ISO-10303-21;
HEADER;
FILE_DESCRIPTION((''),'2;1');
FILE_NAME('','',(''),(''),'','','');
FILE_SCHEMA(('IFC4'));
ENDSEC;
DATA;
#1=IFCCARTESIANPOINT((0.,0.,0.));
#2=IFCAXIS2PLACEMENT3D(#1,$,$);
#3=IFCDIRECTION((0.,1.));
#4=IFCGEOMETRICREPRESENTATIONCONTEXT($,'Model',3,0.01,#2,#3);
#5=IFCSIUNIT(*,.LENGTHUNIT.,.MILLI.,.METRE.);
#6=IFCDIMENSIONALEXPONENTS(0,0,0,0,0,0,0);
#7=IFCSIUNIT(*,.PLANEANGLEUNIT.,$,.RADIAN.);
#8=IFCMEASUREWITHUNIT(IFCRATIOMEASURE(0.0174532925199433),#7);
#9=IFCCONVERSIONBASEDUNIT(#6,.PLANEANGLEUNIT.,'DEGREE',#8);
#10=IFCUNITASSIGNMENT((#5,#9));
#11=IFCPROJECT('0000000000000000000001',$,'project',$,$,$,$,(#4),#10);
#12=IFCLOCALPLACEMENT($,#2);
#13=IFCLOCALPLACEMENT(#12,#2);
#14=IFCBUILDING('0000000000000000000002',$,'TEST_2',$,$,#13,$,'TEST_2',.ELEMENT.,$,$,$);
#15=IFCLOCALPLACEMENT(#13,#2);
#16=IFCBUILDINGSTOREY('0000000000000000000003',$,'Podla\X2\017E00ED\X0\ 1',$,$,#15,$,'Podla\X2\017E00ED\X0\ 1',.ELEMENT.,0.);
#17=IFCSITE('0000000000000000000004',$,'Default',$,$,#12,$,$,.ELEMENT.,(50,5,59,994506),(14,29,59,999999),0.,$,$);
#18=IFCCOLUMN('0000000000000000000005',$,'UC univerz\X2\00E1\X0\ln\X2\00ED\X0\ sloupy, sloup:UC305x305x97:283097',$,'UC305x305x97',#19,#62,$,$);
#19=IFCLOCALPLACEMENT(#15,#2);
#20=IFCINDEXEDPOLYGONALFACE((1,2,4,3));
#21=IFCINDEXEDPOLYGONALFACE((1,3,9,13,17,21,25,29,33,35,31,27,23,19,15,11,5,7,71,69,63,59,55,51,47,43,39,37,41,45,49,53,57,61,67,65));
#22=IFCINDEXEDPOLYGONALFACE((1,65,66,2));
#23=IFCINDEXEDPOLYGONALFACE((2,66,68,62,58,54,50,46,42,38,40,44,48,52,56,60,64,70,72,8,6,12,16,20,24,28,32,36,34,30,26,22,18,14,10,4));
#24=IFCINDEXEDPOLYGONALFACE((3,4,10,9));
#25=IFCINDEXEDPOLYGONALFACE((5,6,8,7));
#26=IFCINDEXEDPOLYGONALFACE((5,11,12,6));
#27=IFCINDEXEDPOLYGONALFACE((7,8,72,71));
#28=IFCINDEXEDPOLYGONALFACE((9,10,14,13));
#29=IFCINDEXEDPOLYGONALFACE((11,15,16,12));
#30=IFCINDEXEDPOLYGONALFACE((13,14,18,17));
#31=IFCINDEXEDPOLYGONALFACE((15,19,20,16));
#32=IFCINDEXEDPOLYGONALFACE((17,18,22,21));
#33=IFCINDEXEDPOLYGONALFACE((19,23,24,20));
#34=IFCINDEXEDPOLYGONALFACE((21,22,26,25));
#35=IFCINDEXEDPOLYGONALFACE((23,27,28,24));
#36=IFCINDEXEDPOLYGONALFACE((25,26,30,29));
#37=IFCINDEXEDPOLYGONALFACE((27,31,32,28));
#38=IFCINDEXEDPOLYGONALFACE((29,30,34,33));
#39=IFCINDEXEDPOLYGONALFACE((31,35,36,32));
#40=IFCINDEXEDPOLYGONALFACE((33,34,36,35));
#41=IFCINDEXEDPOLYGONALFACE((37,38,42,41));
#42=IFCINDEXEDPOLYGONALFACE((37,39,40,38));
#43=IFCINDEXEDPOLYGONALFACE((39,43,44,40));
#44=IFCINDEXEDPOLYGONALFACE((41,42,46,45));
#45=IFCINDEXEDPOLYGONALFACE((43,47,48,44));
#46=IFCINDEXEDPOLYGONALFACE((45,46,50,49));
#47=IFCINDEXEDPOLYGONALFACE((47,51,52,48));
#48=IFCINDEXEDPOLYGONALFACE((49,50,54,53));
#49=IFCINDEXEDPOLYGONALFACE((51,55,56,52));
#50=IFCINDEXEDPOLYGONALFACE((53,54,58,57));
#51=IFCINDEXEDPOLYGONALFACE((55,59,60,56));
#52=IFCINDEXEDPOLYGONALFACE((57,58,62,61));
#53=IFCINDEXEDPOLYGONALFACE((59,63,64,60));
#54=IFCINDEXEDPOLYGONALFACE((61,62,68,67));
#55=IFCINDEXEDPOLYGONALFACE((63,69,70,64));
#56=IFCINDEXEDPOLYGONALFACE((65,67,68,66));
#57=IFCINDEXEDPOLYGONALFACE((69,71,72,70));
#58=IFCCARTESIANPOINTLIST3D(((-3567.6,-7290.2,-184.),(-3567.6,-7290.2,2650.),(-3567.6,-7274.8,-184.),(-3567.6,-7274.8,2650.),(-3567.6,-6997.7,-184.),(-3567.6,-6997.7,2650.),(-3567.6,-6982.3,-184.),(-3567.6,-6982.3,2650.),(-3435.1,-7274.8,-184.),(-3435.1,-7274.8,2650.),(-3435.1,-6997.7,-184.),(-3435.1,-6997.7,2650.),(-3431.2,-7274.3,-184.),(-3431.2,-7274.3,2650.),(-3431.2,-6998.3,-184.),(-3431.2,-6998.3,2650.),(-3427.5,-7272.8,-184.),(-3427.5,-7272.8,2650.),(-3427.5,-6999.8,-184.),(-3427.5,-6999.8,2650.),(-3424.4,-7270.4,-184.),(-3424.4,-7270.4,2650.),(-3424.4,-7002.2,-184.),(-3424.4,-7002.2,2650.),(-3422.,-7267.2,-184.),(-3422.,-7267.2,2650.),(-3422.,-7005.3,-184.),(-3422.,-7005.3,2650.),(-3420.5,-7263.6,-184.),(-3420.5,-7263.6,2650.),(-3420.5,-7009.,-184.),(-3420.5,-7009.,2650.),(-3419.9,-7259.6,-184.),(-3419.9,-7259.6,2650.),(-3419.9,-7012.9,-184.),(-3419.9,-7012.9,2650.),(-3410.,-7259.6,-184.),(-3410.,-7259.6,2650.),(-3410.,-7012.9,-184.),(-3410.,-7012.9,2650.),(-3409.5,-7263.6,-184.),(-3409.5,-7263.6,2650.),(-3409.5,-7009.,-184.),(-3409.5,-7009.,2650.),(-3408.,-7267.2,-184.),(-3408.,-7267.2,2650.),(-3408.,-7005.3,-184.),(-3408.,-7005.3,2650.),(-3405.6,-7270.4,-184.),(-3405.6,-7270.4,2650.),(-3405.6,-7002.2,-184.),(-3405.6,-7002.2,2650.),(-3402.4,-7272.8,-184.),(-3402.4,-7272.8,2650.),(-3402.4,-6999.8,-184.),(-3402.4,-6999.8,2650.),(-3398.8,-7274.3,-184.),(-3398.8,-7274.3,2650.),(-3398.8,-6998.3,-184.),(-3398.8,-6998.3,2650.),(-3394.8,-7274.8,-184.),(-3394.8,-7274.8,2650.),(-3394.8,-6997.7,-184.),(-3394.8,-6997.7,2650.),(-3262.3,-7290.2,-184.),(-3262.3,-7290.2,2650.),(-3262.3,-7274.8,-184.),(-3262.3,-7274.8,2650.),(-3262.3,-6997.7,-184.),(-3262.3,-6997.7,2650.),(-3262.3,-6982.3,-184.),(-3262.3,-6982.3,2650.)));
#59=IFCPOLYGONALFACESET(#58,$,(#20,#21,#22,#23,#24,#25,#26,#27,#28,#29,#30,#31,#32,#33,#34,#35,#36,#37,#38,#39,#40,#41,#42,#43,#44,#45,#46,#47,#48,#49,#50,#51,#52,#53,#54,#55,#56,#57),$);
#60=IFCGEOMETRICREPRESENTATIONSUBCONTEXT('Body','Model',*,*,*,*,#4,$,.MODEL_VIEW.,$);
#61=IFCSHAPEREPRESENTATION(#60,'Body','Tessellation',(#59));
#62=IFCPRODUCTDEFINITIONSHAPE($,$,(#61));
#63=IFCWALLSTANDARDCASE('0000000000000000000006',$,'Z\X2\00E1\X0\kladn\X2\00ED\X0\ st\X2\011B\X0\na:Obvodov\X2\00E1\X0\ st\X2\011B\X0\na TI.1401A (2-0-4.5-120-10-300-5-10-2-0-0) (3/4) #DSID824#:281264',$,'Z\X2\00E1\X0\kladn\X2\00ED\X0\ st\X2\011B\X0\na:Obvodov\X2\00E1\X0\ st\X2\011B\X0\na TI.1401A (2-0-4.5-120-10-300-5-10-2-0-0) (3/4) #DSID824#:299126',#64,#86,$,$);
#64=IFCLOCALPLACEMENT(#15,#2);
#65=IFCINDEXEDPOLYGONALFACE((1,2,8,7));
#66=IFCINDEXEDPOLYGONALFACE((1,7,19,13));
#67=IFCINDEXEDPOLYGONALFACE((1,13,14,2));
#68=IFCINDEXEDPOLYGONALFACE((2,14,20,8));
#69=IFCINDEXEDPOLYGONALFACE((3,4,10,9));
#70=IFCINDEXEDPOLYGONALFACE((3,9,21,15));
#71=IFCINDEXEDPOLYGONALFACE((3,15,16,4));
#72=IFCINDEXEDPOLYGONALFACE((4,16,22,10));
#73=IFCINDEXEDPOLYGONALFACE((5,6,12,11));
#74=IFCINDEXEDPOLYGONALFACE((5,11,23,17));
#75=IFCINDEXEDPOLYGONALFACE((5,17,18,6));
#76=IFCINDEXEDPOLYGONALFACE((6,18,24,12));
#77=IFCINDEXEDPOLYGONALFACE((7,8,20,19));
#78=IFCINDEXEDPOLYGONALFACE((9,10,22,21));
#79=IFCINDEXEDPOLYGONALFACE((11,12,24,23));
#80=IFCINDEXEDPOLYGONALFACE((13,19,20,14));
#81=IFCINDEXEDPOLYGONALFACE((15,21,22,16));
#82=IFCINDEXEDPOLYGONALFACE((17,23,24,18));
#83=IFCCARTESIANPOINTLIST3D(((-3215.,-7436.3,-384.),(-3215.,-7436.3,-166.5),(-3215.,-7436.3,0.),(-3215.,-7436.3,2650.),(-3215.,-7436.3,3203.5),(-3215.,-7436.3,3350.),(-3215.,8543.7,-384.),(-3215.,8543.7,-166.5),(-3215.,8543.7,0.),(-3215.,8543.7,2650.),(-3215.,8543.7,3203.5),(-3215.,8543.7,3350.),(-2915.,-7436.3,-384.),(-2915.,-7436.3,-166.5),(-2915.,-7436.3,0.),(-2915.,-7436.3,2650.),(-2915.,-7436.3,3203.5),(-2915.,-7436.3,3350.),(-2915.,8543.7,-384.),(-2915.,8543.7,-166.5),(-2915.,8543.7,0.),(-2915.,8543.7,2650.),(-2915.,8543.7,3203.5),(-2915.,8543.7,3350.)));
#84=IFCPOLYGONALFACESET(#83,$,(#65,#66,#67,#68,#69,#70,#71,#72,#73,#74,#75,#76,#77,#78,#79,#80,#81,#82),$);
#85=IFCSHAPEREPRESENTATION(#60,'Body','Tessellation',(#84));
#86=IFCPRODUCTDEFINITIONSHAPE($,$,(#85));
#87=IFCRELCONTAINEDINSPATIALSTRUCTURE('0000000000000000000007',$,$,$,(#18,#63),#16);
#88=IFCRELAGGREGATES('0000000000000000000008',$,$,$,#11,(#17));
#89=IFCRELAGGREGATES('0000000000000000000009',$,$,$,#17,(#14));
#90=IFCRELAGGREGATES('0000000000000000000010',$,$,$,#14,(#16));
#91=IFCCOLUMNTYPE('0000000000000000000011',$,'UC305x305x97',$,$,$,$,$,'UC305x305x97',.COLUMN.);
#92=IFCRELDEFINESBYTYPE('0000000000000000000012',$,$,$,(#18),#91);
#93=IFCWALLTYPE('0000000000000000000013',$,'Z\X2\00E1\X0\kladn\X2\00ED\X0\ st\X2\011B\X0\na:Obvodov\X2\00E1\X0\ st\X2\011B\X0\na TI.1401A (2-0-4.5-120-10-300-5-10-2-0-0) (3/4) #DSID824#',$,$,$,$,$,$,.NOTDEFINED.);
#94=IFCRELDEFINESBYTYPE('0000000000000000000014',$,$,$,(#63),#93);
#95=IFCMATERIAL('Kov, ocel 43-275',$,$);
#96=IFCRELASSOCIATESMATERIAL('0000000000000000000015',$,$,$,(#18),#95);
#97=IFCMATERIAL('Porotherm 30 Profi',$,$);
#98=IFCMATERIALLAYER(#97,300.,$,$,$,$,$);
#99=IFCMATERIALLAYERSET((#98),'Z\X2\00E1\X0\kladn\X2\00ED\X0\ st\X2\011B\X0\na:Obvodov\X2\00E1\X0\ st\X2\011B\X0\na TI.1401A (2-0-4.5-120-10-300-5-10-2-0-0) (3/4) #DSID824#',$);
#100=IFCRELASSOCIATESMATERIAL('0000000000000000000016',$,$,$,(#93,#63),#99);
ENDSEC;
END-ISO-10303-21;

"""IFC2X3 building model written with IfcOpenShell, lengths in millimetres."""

from ifc_helpers import new_model, entity, si_unit, converted_unit, direction, frame, frame_2d, origin, origin_2d_with_axis, place, context, subcontext, project, spatial, rectangle, i_section, extrude, source, transform, mapped, material, layer, layer_set, layer_usage, type_object, type_shapes, element, save


model = new_model("IFC2X3")

# Units and contexts
model_context = context("Model", 3, precision=0.01, world=origin(), true_north=direction((0.0, 1.0)))
body_context = subcontext(model_context, "Body", "Model", "MODEL_VIEW")
ifc_project = project(units=[si_unit("LENGTHUNIT", "METRE", prefix="MILLI"), converted_unit("PLANEANGLEUNIT", "DEGREE", entity("IfcRatioMeasure", 0.0174532925199433), si_unit("PLANEANGLEUNIT", "RADIAN"), dimensions=[0, 0, 0, 0, 0, 0, 0])], contexts=[model_context])

# Site, building, storey
site_placement = place(None, origin())
site = spatial("IfcSite", under=ifc_project, at=site_placement, Name="Default", CompositionType="ELEMENT", RefLatitude=(50, 5, 59, 994506), RefLongitude=(14, 29, 59, 999999), RefElevation=0.0)
building_placement = place(site_placement, origin())
building = spatial("IfcBuilding", under=site, at=building_placement, Name="TEST_2", LongName="TEST_2", CompositionType="ELEMENT")
storey_placement = place(building_placement, origin())
storey = spatial("IfcBuildingStorey", under=building, at=storey_placement, Name="Podlaží 1", LongName="Podlaží 1", CompositionType="ELEMENT", Elevation=0.0)

# Column
ifc_material_1 = material(Name="Kov, ocel 43-275")
column_type = type_object("IfcColumnType", Name="UC305x305x97", ElementType="UC305x305x97", PredefinedType="COLUMN")
shared_shape = source(origin(), body_context, "Body", "SweptSolid", [
    extrude(i_section(OverallWidth=305.3, OverallDepth=307.9, WebThickness=9.9, FlangeThickness=15.4, FilletRadius=15.2, at=origin_2d_with_axis()), frame((0.0, 0.0, -184.0), z_axis=(0.0, 0.0, 1.0), x_axis=(-1.0, 0.0, 0.0)), (0.0, 0.0, 1.0), 2834.0),
])
type_shapes(column_type, [shared_shape])
column_placement = place(storey_placement, frame((-3415.0, -7136.3, 0.0)))
element("IfcColumn", 1, at=column_placement, inside=storey, type_object=column_type, material=ifc_material_1, Name="UC univerzální sloupy, sloup:UC305x305x97:283097", ObjectType="UC305x305x97", context=body_context, shape_type="MappedRepresentation", body=[
    mapped(shared_shape, transform((0.0, 0.0, 0.0), scale=1.0)),
])

# Wall, openings
ifc_material_2 = material(Name="Porotherm 30 Profi")
ifc_layer_1 = layer(ifc_material_2, 300.0)
ifc_layer_set_1 = layer_set([ifc_layer_1], Name="Základní stěna:Obvodová stěna TI.1401A (2-0-4.5-120-10-300-5-10-2-0-0) (3/4) #DSID824#")
ifc_layer_usage_1 = layer_usage(ifc_layer_set_1, "AXIS2", "POSITIVE", -150.0)
wall_type_1 = type_object("IfcWallType", Name="Základní stěna:Obvodová stěna TI.1401A (2-0-4.5-120-10-300-5-10-2-0-0) (3/4) #DSID824#", PredefinedType="NOTDEFINED", material=ifc_layer_set_1)
wall_1_placement = place(storey_placement, frame((-3065.0, -7436.3, -384.0), z_axis=(0.0, 0.0, 1.0), x_axis=(0.0, 1.0, 0.0)))
wall_1 = element("IfcWallStandardCase", 2, at=wall_1_placement, inside=storey, type_object=wall_type_1, material=ifc_layer_usage_1, Name="Základní stěna:Obvodová stěna TI.1401A (2-0-4.5-120-10-300-5-10-2-0-0) (3/4) #DSID824#:281264", ObjectType="Základní stěna:Obvodová stěna TI.1401A (2-0-4.5-120-10-300-5-10-2-0-0) (3/4) #DSID824#:299126", context=body_context, shape_type="SweptSolid", body=[
    extrude(rectangle(XDim=15980.0, YDim=300.0, at=frame_2d((7990.0, 0.0), x_axis=(-1.0, 0.0))), origin(), (0.0, 0.0, 1.0), 3734.0),
])
opening_1_placement = place(storey_placement, frame((-3065.0, -7436.3, -384.0), z_axis=(0.0, 0.0, 1.0), x_axis=(0.0, 1.0, 0.0)))
element("IfcOpeningElement", 3, at=opening_1_placement, cuts=wall_1, ObjectType="Opening", context=body_context, shape_type="SweptSolid", body=[
    extrude(rectangle(XDim=15980.0, YDim=300.0, at=origin_2d_with_axis()), frame((7990.0, 0.0, 217.5)), (0.0, 0.0, 1.0), 166.5),
])
opening_2_placement = place(storey_placement, frame((-3065.0, -7436.3, -384.0), z_axis=(0.0, 0.0, 1.0), x_axis=(0.0, 1.0, 0.0)))
element("IfcOpeningElement", 4, at=opening_2_placement, cuts=wall_1, ObjectType="Opening", context=body_context, shape_type="SweptSolid", body=[
    extrude(rectangle(XDim=15980.0, YDim=300.0, at=frame_2d((1538.0, 30.0), x_axis=(1.0, 0.0))), frame((9528.0, 30.0, 3034.0), z_axis=(0.0, 0.0, 1.0), x_axis=(-1.0, 0.0, 0.0)), (0.0, 0.0, 1.0), 553.5),
])

save(model, "model.ifc")
